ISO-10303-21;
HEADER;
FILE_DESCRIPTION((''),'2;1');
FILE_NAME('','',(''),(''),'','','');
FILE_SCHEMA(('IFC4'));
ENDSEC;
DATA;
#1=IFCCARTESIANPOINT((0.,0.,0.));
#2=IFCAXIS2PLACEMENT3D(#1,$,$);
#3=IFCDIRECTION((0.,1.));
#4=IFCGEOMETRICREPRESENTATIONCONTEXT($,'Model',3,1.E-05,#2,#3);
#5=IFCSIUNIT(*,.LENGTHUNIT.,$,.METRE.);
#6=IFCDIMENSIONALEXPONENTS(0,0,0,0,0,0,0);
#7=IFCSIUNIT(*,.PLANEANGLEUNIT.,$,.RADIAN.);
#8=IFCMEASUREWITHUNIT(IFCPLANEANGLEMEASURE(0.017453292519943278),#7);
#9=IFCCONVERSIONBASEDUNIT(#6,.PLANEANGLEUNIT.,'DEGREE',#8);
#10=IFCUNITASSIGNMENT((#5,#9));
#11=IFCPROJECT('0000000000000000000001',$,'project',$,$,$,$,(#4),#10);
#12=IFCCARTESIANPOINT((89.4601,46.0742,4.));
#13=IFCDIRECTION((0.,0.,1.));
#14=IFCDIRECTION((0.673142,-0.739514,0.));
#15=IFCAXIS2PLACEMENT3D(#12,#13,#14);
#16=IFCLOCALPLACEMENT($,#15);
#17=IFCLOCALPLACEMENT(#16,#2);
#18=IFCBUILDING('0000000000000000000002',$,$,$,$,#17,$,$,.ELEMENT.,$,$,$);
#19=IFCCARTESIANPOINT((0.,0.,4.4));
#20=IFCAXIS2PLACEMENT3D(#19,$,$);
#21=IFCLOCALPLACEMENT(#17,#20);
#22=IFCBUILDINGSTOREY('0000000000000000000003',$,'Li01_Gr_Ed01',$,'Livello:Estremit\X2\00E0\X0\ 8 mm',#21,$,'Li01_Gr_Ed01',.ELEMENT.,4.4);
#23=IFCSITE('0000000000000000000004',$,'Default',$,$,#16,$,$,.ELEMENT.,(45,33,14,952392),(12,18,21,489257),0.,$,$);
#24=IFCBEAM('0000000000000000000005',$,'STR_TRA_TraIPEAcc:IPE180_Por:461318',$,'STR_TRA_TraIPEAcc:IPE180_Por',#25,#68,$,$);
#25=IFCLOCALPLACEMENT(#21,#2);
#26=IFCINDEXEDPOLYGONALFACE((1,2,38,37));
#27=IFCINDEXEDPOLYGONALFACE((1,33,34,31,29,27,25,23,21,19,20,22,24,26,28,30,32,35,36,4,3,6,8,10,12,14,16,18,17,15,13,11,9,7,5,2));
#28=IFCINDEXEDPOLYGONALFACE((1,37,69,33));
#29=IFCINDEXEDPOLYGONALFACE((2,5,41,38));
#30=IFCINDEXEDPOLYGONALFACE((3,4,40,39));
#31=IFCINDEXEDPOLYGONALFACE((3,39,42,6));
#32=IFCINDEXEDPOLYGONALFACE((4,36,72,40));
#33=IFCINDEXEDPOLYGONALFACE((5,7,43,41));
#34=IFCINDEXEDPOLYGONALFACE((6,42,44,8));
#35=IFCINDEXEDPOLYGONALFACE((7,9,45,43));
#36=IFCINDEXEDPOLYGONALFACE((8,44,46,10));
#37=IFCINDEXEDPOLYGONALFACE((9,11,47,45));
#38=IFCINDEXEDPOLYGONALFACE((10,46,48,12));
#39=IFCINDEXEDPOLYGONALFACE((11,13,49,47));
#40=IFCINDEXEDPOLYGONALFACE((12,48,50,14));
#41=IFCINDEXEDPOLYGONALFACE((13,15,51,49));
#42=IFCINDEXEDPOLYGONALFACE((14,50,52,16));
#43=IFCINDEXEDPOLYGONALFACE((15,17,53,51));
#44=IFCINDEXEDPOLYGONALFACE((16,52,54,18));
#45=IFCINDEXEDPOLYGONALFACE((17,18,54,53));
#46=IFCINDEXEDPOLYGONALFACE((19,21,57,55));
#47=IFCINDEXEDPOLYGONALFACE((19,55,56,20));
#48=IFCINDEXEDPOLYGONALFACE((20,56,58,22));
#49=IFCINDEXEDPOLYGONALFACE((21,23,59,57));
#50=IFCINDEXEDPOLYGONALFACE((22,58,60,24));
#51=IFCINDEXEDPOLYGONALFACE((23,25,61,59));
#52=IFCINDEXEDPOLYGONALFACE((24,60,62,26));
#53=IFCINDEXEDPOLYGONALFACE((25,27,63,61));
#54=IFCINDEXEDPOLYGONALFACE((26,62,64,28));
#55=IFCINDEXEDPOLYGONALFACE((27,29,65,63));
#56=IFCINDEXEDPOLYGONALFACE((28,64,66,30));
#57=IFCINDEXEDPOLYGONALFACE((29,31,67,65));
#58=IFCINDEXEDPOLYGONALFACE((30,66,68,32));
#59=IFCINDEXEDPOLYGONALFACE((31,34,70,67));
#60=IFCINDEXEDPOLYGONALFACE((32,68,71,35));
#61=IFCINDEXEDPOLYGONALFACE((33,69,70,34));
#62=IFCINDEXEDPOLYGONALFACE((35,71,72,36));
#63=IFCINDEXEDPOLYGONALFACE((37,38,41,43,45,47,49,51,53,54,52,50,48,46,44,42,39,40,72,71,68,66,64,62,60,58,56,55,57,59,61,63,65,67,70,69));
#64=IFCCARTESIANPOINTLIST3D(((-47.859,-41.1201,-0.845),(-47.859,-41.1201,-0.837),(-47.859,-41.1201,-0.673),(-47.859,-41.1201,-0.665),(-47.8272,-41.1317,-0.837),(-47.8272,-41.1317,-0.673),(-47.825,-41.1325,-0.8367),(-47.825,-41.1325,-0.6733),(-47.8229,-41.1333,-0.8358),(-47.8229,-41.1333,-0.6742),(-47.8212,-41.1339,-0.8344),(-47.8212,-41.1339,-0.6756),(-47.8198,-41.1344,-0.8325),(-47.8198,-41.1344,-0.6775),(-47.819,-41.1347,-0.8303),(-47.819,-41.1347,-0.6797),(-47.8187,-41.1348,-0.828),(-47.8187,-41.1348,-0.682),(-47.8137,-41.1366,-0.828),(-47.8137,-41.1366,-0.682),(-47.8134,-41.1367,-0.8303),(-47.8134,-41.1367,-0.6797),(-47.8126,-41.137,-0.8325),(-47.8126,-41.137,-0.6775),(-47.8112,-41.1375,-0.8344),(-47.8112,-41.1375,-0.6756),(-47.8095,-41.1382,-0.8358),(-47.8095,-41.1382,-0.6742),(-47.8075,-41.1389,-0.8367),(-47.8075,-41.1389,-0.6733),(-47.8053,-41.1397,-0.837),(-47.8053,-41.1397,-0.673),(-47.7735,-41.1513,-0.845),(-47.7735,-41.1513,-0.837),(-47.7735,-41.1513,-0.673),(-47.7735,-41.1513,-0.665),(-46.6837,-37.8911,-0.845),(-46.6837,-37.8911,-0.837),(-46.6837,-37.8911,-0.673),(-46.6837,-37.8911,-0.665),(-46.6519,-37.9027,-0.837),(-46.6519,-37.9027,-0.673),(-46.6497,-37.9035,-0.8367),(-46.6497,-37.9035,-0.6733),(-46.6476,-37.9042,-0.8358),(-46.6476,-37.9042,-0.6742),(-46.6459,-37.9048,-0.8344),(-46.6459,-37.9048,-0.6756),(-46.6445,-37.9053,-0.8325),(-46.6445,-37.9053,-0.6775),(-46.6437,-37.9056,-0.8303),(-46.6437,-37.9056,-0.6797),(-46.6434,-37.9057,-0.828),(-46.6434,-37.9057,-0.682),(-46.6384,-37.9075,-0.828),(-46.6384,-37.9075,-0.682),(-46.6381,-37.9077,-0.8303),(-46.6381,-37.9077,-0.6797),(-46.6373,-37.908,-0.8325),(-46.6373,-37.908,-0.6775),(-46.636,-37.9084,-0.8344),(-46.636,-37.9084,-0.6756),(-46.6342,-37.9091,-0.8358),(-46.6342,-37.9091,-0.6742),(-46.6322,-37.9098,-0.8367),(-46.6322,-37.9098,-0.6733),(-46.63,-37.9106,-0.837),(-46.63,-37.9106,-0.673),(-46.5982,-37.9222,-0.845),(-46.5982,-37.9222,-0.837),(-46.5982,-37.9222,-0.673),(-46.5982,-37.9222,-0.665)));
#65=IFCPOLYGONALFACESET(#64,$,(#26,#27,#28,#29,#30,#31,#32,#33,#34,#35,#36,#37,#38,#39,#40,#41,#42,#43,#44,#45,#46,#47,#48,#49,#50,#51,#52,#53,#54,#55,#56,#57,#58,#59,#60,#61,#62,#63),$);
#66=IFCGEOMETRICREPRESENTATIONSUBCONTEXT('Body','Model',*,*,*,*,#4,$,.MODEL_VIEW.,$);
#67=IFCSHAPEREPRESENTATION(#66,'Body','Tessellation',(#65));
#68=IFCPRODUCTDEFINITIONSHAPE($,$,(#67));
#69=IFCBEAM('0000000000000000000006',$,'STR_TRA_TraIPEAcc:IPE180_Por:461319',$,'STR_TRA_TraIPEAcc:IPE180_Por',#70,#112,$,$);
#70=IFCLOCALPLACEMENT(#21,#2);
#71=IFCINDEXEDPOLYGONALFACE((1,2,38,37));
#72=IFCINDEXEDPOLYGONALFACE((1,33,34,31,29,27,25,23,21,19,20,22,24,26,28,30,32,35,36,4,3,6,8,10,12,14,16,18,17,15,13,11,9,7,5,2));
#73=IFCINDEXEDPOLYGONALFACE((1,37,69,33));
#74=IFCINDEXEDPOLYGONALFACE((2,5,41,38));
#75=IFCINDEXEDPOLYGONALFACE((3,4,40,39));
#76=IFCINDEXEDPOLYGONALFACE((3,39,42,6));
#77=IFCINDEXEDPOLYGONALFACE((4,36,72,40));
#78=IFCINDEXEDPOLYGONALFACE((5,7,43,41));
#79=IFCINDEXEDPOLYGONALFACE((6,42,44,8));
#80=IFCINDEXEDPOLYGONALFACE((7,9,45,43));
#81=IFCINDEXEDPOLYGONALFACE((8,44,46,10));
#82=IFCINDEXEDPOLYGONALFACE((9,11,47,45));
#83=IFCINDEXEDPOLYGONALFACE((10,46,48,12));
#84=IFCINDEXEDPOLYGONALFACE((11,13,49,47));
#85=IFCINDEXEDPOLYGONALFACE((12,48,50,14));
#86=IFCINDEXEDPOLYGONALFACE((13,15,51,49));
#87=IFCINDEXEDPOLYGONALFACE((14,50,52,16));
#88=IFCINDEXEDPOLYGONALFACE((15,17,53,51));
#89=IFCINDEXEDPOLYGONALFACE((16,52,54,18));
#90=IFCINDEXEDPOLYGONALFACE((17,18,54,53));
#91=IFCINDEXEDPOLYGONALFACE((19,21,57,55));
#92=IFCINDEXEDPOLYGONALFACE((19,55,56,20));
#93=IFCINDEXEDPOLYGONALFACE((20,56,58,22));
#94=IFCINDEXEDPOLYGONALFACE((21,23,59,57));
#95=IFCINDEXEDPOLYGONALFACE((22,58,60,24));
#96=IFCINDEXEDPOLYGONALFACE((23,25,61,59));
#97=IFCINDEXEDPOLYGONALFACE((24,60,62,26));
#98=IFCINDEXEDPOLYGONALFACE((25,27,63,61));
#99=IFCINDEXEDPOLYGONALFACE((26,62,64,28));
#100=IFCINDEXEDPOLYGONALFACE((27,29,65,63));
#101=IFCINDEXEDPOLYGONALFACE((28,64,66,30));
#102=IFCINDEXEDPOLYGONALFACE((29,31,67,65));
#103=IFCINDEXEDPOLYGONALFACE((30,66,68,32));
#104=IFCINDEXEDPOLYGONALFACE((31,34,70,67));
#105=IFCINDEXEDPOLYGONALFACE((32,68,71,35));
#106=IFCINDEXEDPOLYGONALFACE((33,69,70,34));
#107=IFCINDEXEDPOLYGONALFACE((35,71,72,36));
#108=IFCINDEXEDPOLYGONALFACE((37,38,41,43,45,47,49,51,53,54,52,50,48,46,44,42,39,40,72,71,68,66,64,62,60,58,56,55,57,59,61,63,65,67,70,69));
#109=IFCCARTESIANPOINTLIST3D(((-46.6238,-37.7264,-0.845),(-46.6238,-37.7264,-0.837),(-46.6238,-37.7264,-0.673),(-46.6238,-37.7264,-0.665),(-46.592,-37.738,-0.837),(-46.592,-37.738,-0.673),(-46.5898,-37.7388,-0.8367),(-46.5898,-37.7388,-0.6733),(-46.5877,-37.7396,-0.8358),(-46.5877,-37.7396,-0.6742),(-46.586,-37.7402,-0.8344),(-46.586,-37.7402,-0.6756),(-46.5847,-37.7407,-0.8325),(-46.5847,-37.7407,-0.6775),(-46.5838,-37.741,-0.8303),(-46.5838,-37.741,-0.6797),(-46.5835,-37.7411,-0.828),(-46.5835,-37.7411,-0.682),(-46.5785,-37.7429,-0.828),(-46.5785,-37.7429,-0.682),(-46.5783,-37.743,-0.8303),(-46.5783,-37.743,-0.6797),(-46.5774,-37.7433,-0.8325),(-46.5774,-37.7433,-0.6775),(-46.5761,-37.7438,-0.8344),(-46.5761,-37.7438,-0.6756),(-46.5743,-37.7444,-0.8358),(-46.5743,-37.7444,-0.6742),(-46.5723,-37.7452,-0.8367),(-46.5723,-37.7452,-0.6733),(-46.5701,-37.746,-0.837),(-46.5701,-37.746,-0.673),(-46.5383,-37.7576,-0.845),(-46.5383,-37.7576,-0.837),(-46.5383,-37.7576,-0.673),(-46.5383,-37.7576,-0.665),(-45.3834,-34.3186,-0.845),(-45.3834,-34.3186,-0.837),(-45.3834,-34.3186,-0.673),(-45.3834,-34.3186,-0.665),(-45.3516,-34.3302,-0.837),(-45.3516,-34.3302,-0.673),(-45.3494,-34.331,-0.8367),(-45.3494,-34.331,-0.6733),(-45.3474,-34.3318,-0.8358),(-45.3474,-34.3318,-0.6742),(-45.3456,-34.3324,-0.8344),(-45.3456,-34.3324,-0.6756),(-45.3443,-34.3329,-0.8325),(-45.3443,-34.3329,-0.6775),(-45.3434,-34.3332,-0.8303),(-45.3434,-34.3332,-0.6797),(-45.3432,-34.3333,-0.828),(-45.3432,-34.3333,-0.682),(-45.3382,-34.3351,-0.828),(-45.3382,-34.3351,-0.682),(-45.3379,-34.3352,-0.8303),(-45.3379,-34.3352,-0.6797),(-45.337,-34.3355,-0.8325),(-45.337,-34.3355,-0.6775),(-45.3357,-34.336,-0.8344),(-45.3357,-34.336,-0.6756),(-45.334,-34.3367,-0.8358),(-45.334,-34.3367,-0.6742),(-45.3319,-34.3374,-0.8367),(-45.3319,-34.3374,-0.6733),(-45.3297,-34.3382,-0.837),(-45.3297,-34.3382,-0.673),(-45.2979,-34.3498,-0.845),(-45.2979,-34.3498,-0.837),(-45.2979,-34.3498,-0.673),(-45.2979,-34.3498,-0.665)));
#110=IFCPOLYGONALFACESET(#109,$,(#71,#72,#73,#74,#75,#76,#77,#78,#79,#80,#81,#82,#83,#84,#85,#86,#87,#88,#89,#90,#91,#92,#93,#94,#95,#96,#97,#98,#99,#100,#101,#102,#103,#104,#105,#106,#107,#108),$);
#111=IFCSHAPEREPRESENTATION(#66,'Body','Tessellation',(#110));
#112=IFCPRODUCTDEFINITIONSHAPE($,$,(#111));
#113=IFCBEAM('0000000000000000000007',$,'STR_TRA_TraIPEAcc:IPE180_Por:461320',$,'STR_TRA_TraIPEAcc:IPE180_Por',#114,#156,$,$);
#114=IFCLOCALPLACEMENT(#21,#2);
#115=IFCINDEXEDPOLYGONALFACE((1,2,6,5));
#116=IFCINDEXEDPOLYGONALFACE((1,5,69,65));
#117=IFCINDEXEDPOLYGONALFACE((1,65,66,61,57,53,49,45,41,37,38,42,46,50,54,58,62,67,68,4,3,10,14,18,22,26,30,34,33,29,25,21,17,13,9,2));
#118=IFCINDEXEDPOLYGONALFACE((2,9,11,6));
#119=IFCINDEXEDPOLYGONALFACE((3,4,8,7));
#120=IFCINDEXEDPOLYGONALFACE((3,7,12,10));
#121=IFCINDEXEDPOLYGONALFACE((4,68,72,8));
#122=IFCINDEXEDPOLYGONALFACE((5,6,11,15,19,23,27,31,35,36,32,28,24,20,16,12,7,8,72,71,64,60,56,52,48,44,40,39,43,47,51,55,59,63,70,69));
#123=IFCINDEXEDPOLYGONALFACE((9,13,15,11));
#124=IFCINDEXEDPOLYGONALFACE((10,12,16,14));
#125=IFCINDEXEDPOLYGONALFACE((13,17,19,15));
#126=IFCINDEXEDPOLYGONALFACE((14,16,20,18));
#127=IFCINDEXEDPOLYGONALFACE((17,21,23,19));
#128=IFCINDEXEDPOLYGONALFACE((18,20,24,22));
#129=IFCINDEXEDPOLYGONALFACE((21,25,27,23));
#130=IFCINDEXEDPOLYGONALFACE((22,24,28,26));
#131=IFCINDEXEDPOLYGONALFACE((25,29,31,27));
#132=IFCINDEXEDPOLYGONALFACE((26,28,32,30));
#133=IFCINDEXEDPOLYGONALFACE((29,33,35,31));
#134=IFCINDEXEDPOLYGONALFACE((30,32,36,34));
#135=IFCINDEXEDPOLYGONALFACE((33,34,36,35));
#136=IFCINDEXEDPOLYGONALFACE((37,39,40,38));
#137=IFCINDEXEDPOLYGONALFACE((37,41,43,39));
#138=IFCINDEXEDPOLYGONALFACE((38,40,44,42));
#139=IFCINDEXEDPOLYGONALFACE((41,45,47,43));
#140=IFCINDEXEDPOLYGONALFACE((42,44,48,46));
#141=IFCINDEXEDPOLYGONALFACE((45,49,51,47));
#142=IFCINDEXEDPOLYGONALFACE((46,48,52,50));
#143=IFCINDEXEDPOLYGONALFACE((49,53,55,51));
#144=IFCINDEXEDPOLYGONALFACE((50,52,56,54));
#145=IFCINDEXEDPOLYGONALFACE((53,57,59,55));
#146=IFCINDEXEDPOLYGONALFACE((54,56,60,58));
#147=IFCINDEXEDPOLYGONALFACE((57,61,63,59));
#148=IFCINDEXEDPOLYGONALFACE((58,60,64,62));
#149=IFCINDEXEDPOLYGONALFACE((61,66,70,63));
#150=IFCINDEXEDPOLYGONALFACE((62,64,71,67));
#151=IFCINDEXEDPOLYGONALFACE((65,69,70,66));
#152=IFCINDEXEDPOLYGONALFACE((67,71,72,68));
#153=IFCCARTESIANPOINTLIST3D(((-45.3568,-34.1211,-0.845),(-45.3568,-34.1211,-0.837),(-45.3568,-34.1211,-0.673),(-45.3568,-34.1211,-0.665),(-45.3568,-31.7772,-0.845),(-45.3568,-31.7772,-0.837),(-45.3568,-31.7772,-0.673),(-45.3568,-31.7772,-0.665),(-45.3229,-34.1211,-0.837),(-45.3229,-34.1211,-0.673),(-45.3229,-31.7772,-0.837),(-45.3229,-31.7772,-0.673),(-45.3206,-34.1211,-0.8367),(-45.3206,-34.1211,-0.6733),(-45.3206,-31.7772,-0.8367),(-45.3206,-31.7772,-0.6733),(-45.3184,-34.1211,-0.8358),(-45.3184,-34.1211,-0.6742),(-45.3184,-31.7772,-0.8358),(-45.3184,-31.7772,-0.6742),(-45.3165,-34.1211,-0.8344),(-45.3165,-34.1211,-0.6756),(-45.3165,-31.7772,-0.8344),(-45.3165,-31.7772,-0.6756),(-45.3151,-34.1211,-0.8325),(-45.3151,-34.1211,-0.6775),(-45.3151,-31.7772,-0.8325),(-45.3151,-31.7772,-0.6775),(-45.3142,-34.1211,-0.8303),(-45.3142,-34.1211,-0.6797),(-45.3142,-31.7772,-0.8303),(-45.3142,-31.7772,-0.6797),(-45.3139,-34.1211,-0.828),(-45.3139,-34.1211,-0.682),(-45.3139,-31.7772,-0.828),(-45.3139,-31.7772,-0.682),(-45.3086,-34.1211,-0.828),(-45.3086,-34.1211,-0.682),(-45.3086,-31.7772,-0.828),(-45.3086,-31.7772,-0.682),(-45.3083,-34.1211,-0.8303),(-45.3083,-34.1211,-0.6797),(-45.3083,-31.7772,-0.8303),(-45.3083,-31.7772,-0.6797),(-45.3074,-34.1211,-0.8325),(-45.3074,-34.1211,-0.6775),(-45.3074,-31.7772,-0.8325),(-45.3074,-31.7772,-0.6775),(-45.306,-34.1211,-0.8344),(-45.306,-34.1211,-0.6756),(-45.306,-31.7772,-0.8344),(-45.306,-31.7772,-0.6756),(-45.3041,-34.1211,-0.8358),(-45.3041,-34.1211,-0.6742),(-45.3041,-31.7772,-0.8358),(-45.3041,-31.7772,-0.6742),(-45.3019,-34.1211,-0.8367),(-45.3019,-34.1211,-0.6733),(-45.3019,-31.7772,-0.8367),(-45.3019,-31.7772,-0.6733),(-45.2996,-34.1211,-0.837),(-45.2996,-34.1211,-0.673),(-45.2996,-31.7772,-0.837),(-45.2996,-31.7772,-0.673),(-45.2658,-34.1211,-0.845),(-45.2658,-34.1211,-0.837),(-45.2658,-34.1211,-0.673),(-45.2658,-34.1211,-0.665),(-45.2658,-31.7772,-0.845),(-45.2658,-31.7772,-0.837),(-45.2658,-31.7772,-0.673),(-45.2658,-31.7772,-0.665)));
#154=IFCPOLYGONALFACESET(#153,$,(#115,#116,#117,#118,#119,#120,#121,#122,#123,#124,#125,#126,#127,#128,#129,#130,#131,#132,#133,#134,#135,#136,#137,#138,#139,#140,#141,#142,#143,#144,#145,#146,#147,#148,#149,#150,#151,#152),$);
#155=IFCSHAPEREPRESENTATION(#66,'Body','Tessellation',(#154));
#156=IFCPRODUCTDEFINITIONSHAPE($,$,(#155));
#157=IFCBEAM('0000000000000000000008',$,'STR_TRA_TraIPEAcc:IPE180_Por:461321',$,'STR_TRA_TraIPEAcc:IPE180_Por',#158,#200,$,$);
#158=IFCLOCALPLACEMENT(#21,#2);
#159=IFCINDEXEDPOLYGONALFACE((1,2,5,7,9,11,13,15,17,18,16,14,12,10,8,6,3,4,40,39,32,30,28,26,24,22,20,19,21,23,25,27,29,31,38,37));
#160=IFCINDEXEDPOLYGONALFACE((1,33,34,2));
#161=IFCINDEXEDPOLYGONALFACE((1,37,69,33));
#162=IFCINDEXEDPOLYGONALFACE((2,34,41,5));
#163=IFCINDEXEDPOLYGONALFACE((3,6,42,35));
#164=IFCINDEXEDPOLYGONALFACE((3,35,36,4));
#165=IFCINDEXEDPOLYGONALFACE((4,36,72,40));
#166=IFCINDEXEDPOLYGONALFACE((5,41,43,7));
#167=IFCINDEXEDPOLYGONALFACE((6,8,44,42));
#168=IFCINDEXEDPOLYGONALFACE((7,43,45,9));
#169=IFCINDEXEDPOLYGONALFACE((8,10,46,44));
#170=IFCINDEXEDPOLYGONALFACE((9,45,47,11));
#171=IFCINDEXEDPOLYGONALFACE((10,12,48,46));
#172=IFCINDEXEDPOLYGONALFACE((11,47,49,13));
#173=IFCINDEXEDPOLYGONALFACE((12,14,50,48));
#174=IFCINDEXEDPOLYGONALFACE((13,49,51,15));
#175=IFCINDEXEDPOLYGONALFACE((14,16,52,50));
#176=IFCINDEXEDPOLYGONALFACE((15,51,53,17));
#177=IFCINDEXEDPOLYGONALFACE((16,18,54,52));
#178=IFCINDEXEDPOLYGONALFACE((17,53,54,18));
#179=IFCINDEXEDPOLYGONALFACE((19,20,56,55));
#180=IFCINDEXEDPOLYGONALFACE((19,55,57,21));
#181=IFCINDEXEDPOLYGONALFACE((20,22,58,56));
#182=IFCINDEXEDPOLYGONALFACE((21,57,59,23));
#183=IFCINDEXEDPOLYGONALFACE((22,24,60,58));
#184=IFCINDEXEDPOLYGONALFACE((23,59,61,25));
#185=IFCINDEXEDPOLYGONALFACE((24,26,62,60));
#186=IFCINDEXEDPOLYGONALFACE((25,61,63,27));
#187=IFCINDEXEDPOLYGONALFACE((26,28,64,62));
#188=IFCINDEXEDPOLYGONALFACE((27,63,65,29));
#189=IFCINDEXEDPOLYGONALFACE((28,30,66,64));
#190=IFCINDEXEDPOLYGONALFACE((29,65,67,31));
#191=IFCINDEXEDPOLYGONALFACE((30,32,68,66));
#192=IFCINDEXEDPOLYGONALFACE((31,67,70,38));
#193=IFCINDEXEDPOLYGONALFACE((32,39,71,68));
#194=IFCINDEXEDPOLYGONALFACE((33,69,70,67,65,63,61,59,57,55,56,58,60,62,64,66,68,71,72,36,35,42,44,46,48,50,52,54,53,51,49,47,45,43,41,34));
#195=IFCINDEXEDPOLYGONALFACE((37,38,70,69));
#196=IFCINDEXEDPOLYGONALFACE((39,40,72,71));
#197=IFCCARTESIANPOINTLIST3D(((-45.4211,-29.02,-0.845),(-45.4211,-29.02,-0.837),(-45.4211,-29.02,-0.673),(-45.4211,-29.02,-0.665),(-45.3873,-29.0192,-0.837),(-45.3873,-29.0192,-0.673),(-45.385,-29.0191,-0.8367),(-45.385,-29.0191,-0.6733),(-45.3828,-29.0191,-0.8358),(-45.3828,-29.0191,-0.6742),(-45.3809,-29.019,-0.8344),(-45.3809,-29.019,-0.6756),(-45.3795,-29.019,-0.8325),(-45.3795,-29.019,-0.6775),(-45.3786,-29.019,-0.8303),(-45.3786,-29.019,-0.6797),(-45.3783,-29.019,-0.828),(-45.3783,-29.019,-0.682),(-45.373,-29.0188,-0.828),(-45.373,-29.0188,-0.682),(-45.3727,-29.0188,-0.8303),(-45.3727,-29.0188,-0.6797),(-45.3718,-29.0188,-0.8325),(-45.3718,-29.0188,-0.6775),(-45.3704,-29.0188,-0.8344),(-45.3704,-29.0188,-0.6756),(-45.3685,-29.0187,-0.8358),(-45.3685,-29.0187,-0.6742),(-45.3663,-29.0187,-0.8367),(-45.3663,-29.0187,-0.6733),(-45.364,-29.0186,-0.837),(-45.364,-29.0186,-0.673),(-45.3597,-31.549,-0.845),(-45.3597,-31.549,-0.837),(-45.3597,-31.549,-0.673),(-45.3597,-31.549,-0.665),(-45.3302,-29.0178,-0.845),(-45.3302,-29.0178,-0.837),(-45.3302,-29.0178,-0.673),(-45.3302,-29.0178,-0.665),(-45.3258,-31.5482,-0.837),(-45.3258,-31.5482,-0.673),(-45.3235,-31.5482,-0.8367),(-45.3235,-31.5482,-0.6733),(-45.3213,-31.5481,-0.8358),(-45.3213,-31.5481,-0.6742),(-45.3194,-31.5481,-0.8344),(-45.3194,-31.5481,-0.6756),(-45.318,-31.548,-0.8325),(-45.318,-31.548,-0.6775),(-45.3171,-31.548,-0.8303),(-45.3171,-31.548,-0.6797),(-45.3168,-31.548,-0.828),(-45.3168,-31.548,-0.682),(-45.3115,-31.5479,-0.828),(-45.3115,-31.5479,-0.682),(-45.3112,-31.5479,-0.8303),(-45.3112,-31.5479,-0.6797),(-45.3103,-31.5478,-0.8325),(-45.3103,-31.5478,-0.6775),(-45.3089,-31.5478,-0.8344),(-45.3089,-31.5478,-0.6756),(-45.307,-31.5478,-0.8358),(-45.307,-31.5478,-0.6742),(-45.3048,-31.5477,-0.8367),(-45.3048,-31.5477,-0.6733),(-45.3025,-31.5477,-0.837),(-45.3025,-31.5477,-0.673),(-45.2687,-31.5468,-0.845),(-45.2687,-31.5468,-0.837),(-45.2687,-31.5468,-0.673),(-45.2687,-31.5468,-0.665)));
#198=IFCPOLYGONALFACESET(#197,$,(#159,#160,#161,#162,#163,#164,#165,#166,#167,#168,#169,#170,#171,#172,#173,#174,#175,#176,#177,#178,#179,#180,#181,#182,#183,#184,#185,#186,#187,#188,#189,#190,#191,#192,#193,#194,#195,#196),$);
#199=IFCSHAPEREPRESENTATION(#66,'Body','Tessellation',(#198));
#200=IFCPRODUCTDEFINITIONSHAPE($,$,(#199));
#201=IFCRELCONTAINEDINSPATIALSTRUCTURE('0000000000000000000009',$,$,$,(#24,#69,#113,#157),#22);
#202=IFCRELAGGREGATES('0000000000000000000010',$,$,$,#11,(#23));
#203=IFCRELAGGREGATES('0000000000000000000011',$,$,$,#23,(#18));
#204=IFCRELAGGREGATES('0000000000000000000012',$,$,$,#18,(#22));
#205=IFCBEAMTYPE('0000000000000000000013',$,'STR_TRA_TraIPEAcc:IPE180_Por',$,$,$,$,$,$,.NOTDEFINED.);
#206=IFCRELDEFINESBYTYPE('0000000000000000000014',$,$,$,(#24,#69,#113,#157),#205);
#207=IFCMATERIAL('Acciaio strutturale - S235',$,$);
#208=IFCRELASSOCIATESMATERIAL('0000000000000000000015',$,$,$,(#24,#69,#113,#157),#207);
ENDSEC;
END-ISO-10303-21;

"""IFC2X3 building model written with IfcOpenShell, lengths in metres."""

from ifc_helpers import new_model, entity, si_unit, converted_unit, direction, frame, frame_2d, origin, place, context, subcontext, project, spatial, i_section, extrude, material, type_object, element, save


model = new_model("IFC2X3")

# Units and contexts
model_context = context("Model", 3, precision=1e-05, world=origin(), true_north=direction((0.0, 1.0)))
body_context = subcontext(model_context, "Body", "Model", "MODEL_VIEW")
ifc_project = project(units=[si_unit("LENGTHUNIT", "METRE"), converted_unit("PLANEANGLEUNIT", "DEGREE", entity("IfcPlaneAngleMeasure", 0.017453292519943278), si_unit("PLANEANGLEUNIT", "RADIAN"), dimensions=[0, 0, 0, 0, 0, 0, 0])], contexts=[model_context])

# Site, building, storey
site_placement = place(None, frame((89.4601, 46.0742, 4.0), z_axis=(0.0, 0.0, 1.0), x_axis=(0.673142, -0.739514, 0.0)))
site = spatial("IfcSite", under=ifc_project, at=site_placement, Name="Default", CompositionType="ELEMENT", RefLatitude=(45, 33, 14, 952392), RefLongitude=(12, 18, 21, 489257), RefElevation=0.0)
building_placement = place(site_placement, origin())
building = spatial("IfcBuilding", under=site, at=building_placement, CompositionType="ELEMENT")
storey_placement = place(building_placement, frame((0.0, 0.0, 4.4)))
storey = spatial("IfcBuildingStorey", under=building, at=storey_placement, Name="Li01_Gr_Ed01", ObjectType="Livello:Estremità 8 mm", LongName="Li01_Gr_Ed01", CompositionType="ELEMENT", Elevation=4.4)

# Beams
ifc_material_1 = material(Name="Acciaio strutturale - S235")
beam_type = type_object("IfcBeamType", Name="STR_TRA_TraIPEAcc:IPE180_Por", PredefinedType="NOTDEFINED")
beam_1_placement = place(storey_placement, frame((-47.8456, -41.2165, -0.665), z_axis=(0.0, 0.0, 1.0), x_axis=(0.34202, 0.939693, 0.0)))
element("IfcBeam", 1, at=beam_1_placement, inside=storey, type_object=beam_type, material=ifc_material_1, Name="STR_TRA_TraIPEAcc:IPE180_Por:461318", ObjectType="STR_TRA_TraIPEAcc:IPE180_Por", context=body_context, shape_type="SweptSolid", body=[
    extrude(i_section(OverallWidth=0.091, OverallDepth=0.18, WebThickness=0.0053, FlangeThickness=0.008, FilletRadius=0.009, at=frame_2d((0.0, 0.0), x_axis=(0.0, 1.0))), frame((0.086, 0.0, -0.09), z_axis=(1.0, 0.0, 0.0), x_axis=(0.0, 0.0, -1.0)), (0.0, 0.0, 1.0), 3.4363),
])
beam_2_placement = place(storey_placement, frame((-46.611, -37.8242, -0.665), z_axis=(0.0, 0.0, 1.0), x_axis=(0.342026, 0.93969, 0.0)))
element("IfcBeam", 2, at=beam_2_placement, inside=storey, type_object=beam_type, material=ifc_material_1, Name="STR_TRA_TraIPEAcc:IPE180_Por:461319", ObjectType="STR_TRA_TraIPEAcc:IPE180_Por", context=body_context, shape_type="SweptSolid", body=[
    extrude(i_section(OverallWidth=0.091, OverallDepth=0.18, WebThickness=0.0053, FlangeThickness=0.008, FilletRadius=0.009, at=frame_2d((0.0, 0.0), x_axis=(0.0, 1.0))), frame((0.0875, 0.0, -0.09), z_axis=(1.0, 0.0, 0.0), x_axis=(0.0, 0.0, -1.0)), (0.0, 0.0, 1.0), 3.6265),
])
beam_3_placement = place(storey_placement, frame((-45.3113, -34.2534, -0.665), z_axis=(0.0, 0.0, 1.0), x_axis=(0.0, 1.0, 0.0)))
element("IfcBeam", 3, at=beam_3_placement, inside=storey, type_object=beam_type, material=ifc_material_1, Name="STR_TRA_TraIPEAcc:IPE180_Por:461320", ObjectType="STR_TRA_TraIPEAcc:IPE180_Por", context=body_context, shape_type="SweptSolid", body=[
    extrude(i_section(OverallWidth=0.091, OverallDepth=0.18, WebThickness=0.0053, FlangeThickness=0.008, FilletRadius=0.009, at=frame_2d((0.0, 0.0), x_axis=(0.0, 1.0))), frame((0.1323, 0.0, -0.09), z_axis=(1.0, 0.0, 0.0), x_axis=(0.0, 0.0, -1.0)), (0.0, 0.0, 1.0), 2.3439),
])
beam_4_placement = place(storey_placement, frame((-45.3113, -31.6676, -0.665), z_axis=(0.0, 0.0, 1.0), x_axis=(-0.024299, 0.999705, 0.0)))
element("IfcBeam", 4, at=beam_4_placement, inside=storey, type_object=beam_type, material=ifc_material_1, Name="STR_TRA_TraIPEAcc:IPE180_Por:461321", ObjectType="STR_TRA_TraIPEAcc:IPE180_Por", context=body_context, shape_type="SweptSolid", body=[
    extrude(i_section(OverallWidth=0.091, OverallDepth=0.18, WebThickness=0.0053, FlangeThickness=0.008, FilletRadius=0.009, at=frame_2d((0.0, 0.0), x_axis=(0.0, 1.0))), frame((0.1197, 0.0, -0.09), z_axis=(1.0, 0.0, 0.0), x_axis=(0.0, 0.0, -1.0)), (0.0, 0.0, 1.0), 2.5298),
])

save(model, "model.ifc")
